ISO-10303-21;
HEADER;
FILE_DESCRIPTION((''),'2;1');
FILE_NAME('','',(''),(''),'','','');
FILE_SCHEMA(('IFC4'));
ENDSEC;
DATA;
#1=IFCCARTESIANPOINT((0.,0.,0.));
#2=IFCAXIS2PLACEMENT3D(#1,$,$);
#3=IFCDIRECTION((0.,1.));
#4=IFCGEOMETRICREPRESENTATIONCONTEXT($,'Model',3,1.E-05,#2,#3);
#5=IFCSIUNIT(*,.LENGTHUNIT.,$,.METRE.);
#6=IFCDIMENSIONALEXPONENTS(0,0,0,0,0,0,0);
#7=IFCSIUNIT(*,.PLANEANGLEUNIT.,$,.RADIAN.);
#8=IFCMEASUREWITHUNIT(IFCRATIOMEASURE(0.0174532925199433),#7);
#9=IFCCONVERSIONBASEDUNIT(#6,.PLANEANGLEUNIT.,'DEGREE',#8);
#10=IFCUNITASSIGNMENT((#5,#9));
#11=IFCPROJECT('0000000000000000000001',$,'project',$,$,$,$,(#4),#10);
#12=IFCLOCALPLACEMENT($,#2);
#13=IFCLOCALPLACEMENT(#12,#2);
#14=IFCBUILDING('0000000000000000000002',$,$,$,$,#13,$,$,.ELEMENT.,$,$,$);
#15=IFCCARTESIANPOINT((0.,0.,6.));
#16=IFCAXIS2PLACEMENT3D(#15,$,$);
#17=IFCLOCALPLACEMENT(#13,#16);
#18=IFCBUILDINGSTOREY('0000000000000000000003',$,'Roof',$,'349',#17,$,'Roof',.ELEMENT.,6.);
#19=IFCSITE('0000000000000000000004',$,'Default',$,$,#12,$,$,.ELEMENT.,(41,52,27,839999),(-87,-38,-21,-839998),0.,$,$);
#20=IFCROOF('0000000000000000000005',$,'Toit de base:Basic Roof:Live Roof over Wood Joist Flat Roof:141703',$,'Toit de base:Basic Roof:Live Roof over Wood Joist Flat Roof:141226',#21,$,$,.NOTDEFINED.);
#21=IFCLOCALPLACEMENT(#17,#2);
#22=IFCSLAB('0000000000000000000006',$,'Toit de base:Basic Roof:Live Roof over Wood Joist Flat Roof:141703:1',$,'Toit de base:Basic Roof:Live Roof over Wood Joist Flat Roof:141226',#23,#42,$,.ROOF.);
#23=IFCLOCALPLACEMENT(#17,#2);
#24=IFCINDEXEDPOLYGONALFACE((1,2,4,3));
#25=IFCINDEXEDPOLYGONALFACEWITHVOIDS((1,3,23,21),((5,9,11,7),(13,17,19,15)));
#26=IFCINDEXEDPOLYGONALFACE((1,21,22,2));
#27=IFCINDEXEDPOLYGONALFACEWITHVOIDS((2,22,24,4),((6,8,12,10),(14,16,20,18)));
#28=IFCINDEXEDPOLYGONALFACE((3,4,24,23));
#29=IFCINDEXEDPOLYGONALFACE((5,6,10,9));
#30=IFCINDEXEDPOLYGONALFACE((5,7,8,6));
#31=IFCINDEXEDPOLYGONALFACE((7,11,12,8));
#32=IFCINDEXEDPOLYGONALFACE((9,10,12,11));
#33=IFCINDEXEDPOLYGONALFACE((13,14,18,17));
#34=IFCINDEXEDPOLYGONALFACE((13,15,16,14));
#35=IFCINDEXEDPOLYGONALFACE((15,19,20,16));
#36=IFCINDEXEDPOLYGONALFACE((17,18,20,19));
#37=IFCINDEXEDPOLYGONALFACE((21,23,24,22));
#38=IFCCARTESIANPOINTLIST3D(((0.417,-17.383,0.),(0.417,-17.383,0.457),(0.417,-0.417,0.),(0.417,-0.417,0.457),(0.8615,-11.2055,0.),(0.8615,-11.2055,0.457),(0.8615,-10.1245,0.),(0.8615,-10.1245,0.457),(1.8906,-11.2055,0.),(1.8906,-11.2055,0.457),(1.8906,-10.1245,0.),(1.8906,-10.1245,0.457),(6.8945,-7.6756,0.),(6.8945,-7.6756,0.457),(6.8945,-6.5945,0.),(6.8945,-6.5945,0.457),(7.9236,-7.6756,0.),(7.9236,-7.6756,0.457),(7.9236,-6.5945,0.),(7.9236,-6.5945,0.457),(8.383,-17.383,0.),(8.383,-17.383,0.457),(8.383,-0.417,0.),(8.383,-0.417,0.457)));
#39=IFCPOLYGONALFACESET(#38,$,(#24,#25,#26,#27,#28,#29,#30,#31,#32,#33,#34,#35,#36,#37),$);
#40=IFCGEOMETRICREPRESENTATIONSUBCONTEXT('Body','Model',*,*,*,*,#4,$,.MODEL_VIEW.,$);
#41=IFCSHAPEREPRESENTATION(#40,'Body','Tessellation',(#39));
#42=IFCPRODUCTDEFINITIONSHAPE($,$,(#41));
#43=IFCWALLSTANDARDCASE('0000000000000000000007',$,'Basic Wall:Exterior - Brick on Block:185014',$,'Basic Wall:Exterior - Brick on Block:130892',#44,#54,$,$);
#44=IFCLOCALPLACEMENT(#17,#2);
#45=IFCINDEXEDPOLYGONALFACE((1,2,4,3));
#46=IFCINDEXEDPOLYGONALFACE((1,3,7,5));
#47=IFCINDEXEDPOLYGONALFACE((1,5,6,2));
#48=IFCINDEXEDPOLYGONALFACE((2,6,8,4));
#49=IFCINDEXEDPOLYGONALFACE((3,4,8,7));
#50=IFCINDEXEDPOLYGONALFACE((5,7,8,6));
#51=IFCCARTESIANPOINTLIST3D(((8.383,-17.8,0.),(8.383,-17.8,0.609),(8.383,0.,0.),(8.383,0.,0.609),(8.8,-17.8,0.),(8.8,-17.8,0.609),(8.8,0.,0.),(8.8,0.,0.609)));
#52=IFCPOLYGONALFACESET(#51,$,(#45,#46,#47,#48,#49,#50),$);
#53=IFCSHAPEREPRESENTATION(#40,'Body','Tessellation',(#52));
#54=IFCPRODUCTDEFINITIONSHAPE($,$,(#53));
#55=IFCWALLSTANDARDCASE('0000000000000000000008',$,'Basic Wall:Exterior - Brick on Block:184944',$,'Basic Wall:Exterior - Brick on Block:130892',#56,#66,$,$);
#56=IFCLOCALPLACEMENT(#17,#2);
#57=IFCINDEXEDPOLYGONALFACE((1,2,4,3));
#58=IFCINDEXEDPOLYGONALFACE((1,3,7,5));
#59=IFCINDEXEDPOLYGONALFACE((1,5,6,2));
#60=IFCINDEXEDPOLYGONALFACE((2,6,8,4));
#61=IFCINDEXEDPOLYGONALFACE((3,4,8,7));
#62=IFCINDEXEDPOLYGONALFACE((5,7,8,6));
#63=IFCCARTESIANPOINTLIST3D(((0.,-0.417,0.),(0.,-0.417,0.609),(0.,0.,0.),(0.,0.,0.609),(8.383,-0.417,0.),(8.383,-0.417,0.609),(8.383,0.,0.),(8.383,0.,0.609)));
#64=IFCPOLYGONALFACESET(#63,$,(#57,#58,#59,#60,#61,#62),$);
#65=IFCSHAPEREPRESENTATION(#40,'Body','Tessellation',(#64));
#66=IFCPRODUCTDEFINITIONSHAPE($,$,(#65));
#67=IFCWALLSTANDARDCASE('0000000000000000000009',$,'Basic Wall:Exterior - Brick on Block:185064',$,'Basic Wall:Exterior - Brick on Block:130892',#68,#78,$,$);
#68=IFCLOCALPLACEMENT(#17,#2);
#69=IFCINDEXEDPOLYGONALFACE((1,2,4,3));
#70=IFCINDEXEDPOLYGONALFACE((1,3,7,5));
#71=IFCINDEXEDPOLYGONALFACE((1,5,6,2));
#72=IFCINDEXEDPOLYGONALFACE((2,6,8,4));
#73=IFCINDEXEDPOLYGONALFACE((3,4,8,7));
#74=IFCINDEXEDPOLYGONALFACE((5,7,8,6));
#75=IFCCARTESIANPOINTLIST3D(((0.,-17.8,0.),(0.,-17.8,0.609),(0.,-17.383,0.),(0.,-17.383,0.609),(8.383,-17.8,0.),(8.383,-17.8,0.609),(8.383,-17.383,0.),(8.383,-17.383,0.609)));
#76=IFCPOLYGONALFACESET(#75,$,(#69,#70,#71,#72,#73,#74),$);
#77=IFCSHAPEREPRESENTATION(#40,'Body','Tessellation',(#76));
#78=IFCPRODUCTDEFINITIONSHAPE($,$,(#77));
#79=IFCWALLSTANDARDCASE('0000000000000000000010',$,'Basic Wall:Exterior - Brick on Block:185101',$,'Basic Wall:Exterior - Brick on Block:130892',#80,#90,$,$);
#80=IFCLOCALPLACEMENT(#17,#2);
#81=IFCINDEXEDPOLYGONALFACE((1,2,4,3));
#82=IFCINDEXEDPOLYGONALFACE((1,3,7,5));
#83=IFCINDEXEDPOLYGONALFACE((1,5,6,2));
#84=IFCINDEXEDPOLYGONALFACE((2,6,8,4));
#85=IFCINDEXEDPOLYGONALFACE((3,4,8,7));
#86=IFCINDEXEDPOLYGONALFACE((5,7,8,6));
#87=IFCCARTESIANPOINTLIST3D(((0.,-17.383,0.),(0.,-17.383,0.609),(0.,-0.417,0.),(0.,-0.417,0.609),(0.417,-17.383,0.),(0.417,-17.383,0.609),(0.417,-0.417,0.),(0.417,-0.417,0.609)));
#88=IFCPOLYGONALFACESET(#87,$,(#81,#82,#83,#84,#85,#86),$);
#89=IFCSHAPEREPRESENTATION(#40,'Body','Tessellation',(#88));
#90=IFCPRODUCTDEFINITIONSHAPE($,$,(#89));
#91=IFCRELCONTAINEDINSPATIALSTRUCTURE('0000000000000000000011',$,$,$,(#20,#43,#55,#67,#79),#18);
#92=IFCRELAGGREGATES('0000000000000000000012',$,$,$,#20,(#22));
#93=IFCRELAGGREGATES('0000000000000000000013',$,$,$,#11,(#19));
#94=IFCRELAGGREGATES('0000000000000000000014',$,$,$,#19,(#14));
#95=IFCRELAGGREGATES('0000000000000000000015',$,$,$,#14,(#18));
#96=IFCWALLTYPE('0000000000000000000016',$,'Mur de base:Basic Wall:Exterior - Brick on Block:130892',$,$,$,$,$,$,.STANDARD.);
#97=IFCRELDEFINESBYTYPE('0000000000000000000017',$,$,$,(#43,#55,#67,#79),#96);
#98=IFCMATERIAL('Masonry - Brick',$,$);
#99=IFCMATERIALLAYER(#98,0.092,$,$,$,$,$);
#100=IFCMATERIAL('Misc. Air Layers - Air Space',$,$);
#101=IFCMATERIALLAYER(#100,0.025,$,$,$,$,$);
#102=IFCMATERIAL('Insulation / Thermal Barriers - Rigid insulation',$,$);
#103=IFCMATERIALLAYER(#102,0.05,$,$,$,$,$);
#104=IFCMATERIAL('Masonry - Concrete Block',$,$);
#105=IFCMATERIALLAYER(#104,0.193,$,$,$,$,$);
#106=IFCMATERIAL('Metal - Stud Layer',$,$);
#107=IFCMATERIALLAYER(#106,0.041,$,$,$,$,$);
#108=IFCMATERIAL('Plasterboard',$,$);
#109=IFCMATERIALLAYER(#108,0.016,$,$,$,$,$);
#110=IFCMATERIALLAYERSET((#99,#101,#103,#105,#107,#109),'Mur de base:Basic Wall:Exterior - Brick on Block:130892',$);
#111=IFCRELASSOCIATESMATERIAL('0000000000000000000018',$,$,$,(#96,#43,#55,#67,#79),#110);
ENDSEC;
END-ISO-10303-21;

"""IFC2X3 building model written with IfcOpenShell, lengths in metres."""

from ifc_helpers import new_model, entity, si_unit, converted_unit, direction, frame, frame_2d, origin, origin_2d_with_axis, place, context, subcontext, project, spatial, rectangle, extrude, material, layer, layer_set, layer_usage, type_object, element, aggregate, save


model = new_model("IFC2X3")

# Units and contexts
model_context = context("Model", 3, precision=1e-05, world=origin(), true_north=direction((0.0, 1.0)))
body_context = subcontext(model_context, "Body", "Model", "MODEL_VIEW")
ifc_project = project(units=[si_unit("LENGTHUNIT", "METRE"), converted_unit("PLANEANGLEUNIT", "DEGREE", entity("IfcRatioMeasure", 0.0174532925199433), si_unit("PLANEANGLEUNIT", "RADIAN"), dimensions=[0, 0, 0, 0, 0, 0, 0])], contexts=[model_context])

# Site, building, storey
site_placement = place(None, origin())
site = spatial("IfcSite", under=ifc_project, at=site_placement, Name="Default", CompositionType="ELEMENT", RefLatitude=(41, 52, 27, 839999), RefLongitude=(-87, -38, -21, -839998), RefElevation=0.0)
building_placement = place(site_placement, origin())
building = spatial("IfcBuilding", under=site, at=building_placement, CompositionType="ELEMENT")
storey_placement = place(building_placement, frame((0.0, 0.0, 6.0)))
storey = spatial("IfcBuildingStorey", under=building, at=storey_placement, Name="Roof", ObjectType="349", LongName="Roof", CompositionType="ELEMENT", Elevation=6.0)

# Roof, slab, openings
roof_placement = place(storey_placement, origin())
roof = element("IfcRoof", 1, at=roof_placement, inside=storey, Name="Toit de base:Basic Roof:Live Roof over Wood Joist Flat Roof:141703", ObjectType="Toit de base:Basic Roof:Live Roof over Wood Joist Flat Roof:141226", ShapeType="NOTDEFINED")
slab_placement = place(storey_placement, origin())
slab = element("IfcSlab", 2, at=slab_placement, Name="Toit de base:Basic Roof:Live Roof over Wood Joist Flat Roof:141703:1", ObjectType="Toit de base:Basic Roof:Live Roof over Wood Joist Flat Roof:141226", PredefinedType="ROOF", context=body_context, shape_type="SweptSolid", body=[
    extrude(rectangle(XDim=16.966, YDim=7.966, at=origin_2d_with_axis()), frame((4.4, -8.9, 0.0), z_axis=(0.0, 0.0, 1.0), x_axis=(0.0, 1.0, 0.0)), (0.0, 0.0, 1.0), 0.457),
])
opening_1_placement = place(storey_placement, origin())
element("IfcOpeningElement", 3, at=opening_1_placement, cuts=slab, ObjectType="Opening", context=body_context, shape_type="SweptSolid", body=[
    extrude(rectangle(XDim=1.0291, YDim=1.0811, at=frame_2d((0.0, 0.0), x_axis=(1.0, 0.0))), frame((1.376, -10.665, 0.0)), (0.0, 0.0, 1.0), 0.457),
])
opening_2_placement = place(storey_placement, origin())
element("IfcOpeningElement", 4, at=opening_2_placement, cuts=slab, ObjectType="Opening", context=body_context, shape_type="SweptSolid", body=[
    extrude(rectangle(XDim=1.0291, YDim=1.0811, at=frame_2d((0.0, 0.0), x_axis=(1.0, 0.0))), frame((7.409, -7.135, 0.0)), (0.0, 0.0, 1.0), 0.457),
])
aggregate(roof, [slab])

# Walls
ifc_material_1 = material(Name="Masonry - Brick")
ifc_layer_1 = layer(ifc_material_1, 0.092)
ifc_material_2 = material(Name="Misc. Air Layers - Air Space")
ifc_layer_2 = layer(ifc_material_2, 0.025)
ifc_material_3 = material(Name="Insulation / Thermal Barriers - Rigid insulation")
ifc_layer_3 = layer(ifc_material_3, 0.05)
ifc_material_4 = material(Name="Masonry - Concrete Block")
ifc_layer_4 = layer(ifc_material_4, 0.193)
ifc_material_5 = material(Name="Metal - Stud Layer")
ifc_layer_5 = layer(ifc_material_5, 0.041)
ifc_material_6 = material(Name="Plasterboard")
ifc_layer_6 = layer(ifc_material_6, 0.016)
ifc_layer_set = layer_set([ifc_layer_1, ifc_layer_2, ifc_layer_3, ifc_layer_4, ifc_layer_5, ifc_layer_6], Name="Mur de base:Basic Wall:Exterior - Brick on Block:130892")
ifc_layer_usage_1 = layer_usage(ifc_layer_set, "AXIS2", "NEGATIVE", 0.2085)
wall_type = type_object("IfcWallType", Name="Mur de base:Basic Wall:Exterior - Brick on Block:130892", PredefinedType="STANDARD", material=ifc_layer_set)
wall_1_placement = place(storey_placement, frame((8.5915, 0.0, 0.0), z_axis=(0.0, 0.0, 1.0), x_axis=(0.0, -1.0, 0.0)))
element("IfcWallStandardCase", 5, at=wall_1_placement, inside=storey, type_object=wall_type, material=ifc_layer_usage_1, Name="Basic Wall:Exterior - Brick on Block:185014", ObjectType="Basic Wall:Exterior - Brick on Block:130892", context=body_context, shape_type="SweptSolid", body=[
    extrude(rectangle(XDim=17.8, YDim=0.417, at=frame_2d((8.9, 0.0), x_axis=(-1.0, 0.0))), origin(), (0.0, 0.0, 1.0), 0.609),
])
ifc_layer_usage_2 = layer_usage(ifc_layer_set, "AXIS2", "NEGATIVE", 0.2085)
wall_2_placement = place(storey_placement, frame((0.0, -0.2085, 0.0)))
element("IfcWallStandardCase", 6, at=wall_2_placement, inside=storey, type_object=wall_type, material=ifc_layer_usage_2, Name="Basic Wall:Exterior - Brick on Block:184944", ObjectType="Basic Wall:Exterior - Brick on Block:130892", context=body_context, shape_type="SweptSolid", body=[
    extrude(rectangle(XDim=8.383, YDim=0.417, at=frame_2d((4.1915, 0.0), x_axis=(-1.0, 0.0))), origin(), (0.0, 0.0, 1.0), 0.609),
])
ifc_layer_usage_3 = layer_usage(ifc_layer_set, "AXIS2", "NEGATIVE", 0.2085)
wall_3_placement = place(storey_placement, frame((8.383, -17.5915, 0.0), z_axis=(0.0, 0.0, 1.0), x_axis=(-1.0, 0.0, 0.0)))
element("IfcWallStandardCase", 7, at=wall_3_placement, inside=storey, type_object=wall_type, material=ifc_layer_usage_3, Name="Basic Wall:Exterior - Brick on Block:185064", ObjectType="Basic Wall:Exterior - Brick on Block:130892", context=body_context, shape_type="SweptSolid", body=[
    extrude(rectangle(XDim=8.383, YDim=0.417, at=frame_2d((4.1915, 0.0), x_axis=(-1.0, 0.0))), origin(), (0.0, 0.0, 1.0), 0.609),
])
ifc_layer_usage_4 = layer_usage(ifc_layer_set, "AXIS2", "NEGATIVE", 0.2085)
wall_4_placement = place(storey_placement, frame((0.2085, -17.383, 0.0), z_axis=(0.0, 0.0, 1.0), x_axis=(0.0, 1.0, 0.0)))
element("IfcWallStandardCase", 8, at=wall_4_placement, inside=storey, type_object=wall_type, material=ifc_layer_usage_4, Name="Basic Wall:Exterior - Brick on Block:185101", ObjectType="Basic Wall:Exterior - Brick on Block:130892", context=body_context, shape_type="SweptSolid", body=[
    extrude(rectangle(XDim=16.966, YDim=0.417, at=frame_2d((8.483, 0.0), x_axis=(-1.0, 0.0))), origin(), (0.0, 0.0, 1.0), 0.609),
])

save(model, "model.ifc")
